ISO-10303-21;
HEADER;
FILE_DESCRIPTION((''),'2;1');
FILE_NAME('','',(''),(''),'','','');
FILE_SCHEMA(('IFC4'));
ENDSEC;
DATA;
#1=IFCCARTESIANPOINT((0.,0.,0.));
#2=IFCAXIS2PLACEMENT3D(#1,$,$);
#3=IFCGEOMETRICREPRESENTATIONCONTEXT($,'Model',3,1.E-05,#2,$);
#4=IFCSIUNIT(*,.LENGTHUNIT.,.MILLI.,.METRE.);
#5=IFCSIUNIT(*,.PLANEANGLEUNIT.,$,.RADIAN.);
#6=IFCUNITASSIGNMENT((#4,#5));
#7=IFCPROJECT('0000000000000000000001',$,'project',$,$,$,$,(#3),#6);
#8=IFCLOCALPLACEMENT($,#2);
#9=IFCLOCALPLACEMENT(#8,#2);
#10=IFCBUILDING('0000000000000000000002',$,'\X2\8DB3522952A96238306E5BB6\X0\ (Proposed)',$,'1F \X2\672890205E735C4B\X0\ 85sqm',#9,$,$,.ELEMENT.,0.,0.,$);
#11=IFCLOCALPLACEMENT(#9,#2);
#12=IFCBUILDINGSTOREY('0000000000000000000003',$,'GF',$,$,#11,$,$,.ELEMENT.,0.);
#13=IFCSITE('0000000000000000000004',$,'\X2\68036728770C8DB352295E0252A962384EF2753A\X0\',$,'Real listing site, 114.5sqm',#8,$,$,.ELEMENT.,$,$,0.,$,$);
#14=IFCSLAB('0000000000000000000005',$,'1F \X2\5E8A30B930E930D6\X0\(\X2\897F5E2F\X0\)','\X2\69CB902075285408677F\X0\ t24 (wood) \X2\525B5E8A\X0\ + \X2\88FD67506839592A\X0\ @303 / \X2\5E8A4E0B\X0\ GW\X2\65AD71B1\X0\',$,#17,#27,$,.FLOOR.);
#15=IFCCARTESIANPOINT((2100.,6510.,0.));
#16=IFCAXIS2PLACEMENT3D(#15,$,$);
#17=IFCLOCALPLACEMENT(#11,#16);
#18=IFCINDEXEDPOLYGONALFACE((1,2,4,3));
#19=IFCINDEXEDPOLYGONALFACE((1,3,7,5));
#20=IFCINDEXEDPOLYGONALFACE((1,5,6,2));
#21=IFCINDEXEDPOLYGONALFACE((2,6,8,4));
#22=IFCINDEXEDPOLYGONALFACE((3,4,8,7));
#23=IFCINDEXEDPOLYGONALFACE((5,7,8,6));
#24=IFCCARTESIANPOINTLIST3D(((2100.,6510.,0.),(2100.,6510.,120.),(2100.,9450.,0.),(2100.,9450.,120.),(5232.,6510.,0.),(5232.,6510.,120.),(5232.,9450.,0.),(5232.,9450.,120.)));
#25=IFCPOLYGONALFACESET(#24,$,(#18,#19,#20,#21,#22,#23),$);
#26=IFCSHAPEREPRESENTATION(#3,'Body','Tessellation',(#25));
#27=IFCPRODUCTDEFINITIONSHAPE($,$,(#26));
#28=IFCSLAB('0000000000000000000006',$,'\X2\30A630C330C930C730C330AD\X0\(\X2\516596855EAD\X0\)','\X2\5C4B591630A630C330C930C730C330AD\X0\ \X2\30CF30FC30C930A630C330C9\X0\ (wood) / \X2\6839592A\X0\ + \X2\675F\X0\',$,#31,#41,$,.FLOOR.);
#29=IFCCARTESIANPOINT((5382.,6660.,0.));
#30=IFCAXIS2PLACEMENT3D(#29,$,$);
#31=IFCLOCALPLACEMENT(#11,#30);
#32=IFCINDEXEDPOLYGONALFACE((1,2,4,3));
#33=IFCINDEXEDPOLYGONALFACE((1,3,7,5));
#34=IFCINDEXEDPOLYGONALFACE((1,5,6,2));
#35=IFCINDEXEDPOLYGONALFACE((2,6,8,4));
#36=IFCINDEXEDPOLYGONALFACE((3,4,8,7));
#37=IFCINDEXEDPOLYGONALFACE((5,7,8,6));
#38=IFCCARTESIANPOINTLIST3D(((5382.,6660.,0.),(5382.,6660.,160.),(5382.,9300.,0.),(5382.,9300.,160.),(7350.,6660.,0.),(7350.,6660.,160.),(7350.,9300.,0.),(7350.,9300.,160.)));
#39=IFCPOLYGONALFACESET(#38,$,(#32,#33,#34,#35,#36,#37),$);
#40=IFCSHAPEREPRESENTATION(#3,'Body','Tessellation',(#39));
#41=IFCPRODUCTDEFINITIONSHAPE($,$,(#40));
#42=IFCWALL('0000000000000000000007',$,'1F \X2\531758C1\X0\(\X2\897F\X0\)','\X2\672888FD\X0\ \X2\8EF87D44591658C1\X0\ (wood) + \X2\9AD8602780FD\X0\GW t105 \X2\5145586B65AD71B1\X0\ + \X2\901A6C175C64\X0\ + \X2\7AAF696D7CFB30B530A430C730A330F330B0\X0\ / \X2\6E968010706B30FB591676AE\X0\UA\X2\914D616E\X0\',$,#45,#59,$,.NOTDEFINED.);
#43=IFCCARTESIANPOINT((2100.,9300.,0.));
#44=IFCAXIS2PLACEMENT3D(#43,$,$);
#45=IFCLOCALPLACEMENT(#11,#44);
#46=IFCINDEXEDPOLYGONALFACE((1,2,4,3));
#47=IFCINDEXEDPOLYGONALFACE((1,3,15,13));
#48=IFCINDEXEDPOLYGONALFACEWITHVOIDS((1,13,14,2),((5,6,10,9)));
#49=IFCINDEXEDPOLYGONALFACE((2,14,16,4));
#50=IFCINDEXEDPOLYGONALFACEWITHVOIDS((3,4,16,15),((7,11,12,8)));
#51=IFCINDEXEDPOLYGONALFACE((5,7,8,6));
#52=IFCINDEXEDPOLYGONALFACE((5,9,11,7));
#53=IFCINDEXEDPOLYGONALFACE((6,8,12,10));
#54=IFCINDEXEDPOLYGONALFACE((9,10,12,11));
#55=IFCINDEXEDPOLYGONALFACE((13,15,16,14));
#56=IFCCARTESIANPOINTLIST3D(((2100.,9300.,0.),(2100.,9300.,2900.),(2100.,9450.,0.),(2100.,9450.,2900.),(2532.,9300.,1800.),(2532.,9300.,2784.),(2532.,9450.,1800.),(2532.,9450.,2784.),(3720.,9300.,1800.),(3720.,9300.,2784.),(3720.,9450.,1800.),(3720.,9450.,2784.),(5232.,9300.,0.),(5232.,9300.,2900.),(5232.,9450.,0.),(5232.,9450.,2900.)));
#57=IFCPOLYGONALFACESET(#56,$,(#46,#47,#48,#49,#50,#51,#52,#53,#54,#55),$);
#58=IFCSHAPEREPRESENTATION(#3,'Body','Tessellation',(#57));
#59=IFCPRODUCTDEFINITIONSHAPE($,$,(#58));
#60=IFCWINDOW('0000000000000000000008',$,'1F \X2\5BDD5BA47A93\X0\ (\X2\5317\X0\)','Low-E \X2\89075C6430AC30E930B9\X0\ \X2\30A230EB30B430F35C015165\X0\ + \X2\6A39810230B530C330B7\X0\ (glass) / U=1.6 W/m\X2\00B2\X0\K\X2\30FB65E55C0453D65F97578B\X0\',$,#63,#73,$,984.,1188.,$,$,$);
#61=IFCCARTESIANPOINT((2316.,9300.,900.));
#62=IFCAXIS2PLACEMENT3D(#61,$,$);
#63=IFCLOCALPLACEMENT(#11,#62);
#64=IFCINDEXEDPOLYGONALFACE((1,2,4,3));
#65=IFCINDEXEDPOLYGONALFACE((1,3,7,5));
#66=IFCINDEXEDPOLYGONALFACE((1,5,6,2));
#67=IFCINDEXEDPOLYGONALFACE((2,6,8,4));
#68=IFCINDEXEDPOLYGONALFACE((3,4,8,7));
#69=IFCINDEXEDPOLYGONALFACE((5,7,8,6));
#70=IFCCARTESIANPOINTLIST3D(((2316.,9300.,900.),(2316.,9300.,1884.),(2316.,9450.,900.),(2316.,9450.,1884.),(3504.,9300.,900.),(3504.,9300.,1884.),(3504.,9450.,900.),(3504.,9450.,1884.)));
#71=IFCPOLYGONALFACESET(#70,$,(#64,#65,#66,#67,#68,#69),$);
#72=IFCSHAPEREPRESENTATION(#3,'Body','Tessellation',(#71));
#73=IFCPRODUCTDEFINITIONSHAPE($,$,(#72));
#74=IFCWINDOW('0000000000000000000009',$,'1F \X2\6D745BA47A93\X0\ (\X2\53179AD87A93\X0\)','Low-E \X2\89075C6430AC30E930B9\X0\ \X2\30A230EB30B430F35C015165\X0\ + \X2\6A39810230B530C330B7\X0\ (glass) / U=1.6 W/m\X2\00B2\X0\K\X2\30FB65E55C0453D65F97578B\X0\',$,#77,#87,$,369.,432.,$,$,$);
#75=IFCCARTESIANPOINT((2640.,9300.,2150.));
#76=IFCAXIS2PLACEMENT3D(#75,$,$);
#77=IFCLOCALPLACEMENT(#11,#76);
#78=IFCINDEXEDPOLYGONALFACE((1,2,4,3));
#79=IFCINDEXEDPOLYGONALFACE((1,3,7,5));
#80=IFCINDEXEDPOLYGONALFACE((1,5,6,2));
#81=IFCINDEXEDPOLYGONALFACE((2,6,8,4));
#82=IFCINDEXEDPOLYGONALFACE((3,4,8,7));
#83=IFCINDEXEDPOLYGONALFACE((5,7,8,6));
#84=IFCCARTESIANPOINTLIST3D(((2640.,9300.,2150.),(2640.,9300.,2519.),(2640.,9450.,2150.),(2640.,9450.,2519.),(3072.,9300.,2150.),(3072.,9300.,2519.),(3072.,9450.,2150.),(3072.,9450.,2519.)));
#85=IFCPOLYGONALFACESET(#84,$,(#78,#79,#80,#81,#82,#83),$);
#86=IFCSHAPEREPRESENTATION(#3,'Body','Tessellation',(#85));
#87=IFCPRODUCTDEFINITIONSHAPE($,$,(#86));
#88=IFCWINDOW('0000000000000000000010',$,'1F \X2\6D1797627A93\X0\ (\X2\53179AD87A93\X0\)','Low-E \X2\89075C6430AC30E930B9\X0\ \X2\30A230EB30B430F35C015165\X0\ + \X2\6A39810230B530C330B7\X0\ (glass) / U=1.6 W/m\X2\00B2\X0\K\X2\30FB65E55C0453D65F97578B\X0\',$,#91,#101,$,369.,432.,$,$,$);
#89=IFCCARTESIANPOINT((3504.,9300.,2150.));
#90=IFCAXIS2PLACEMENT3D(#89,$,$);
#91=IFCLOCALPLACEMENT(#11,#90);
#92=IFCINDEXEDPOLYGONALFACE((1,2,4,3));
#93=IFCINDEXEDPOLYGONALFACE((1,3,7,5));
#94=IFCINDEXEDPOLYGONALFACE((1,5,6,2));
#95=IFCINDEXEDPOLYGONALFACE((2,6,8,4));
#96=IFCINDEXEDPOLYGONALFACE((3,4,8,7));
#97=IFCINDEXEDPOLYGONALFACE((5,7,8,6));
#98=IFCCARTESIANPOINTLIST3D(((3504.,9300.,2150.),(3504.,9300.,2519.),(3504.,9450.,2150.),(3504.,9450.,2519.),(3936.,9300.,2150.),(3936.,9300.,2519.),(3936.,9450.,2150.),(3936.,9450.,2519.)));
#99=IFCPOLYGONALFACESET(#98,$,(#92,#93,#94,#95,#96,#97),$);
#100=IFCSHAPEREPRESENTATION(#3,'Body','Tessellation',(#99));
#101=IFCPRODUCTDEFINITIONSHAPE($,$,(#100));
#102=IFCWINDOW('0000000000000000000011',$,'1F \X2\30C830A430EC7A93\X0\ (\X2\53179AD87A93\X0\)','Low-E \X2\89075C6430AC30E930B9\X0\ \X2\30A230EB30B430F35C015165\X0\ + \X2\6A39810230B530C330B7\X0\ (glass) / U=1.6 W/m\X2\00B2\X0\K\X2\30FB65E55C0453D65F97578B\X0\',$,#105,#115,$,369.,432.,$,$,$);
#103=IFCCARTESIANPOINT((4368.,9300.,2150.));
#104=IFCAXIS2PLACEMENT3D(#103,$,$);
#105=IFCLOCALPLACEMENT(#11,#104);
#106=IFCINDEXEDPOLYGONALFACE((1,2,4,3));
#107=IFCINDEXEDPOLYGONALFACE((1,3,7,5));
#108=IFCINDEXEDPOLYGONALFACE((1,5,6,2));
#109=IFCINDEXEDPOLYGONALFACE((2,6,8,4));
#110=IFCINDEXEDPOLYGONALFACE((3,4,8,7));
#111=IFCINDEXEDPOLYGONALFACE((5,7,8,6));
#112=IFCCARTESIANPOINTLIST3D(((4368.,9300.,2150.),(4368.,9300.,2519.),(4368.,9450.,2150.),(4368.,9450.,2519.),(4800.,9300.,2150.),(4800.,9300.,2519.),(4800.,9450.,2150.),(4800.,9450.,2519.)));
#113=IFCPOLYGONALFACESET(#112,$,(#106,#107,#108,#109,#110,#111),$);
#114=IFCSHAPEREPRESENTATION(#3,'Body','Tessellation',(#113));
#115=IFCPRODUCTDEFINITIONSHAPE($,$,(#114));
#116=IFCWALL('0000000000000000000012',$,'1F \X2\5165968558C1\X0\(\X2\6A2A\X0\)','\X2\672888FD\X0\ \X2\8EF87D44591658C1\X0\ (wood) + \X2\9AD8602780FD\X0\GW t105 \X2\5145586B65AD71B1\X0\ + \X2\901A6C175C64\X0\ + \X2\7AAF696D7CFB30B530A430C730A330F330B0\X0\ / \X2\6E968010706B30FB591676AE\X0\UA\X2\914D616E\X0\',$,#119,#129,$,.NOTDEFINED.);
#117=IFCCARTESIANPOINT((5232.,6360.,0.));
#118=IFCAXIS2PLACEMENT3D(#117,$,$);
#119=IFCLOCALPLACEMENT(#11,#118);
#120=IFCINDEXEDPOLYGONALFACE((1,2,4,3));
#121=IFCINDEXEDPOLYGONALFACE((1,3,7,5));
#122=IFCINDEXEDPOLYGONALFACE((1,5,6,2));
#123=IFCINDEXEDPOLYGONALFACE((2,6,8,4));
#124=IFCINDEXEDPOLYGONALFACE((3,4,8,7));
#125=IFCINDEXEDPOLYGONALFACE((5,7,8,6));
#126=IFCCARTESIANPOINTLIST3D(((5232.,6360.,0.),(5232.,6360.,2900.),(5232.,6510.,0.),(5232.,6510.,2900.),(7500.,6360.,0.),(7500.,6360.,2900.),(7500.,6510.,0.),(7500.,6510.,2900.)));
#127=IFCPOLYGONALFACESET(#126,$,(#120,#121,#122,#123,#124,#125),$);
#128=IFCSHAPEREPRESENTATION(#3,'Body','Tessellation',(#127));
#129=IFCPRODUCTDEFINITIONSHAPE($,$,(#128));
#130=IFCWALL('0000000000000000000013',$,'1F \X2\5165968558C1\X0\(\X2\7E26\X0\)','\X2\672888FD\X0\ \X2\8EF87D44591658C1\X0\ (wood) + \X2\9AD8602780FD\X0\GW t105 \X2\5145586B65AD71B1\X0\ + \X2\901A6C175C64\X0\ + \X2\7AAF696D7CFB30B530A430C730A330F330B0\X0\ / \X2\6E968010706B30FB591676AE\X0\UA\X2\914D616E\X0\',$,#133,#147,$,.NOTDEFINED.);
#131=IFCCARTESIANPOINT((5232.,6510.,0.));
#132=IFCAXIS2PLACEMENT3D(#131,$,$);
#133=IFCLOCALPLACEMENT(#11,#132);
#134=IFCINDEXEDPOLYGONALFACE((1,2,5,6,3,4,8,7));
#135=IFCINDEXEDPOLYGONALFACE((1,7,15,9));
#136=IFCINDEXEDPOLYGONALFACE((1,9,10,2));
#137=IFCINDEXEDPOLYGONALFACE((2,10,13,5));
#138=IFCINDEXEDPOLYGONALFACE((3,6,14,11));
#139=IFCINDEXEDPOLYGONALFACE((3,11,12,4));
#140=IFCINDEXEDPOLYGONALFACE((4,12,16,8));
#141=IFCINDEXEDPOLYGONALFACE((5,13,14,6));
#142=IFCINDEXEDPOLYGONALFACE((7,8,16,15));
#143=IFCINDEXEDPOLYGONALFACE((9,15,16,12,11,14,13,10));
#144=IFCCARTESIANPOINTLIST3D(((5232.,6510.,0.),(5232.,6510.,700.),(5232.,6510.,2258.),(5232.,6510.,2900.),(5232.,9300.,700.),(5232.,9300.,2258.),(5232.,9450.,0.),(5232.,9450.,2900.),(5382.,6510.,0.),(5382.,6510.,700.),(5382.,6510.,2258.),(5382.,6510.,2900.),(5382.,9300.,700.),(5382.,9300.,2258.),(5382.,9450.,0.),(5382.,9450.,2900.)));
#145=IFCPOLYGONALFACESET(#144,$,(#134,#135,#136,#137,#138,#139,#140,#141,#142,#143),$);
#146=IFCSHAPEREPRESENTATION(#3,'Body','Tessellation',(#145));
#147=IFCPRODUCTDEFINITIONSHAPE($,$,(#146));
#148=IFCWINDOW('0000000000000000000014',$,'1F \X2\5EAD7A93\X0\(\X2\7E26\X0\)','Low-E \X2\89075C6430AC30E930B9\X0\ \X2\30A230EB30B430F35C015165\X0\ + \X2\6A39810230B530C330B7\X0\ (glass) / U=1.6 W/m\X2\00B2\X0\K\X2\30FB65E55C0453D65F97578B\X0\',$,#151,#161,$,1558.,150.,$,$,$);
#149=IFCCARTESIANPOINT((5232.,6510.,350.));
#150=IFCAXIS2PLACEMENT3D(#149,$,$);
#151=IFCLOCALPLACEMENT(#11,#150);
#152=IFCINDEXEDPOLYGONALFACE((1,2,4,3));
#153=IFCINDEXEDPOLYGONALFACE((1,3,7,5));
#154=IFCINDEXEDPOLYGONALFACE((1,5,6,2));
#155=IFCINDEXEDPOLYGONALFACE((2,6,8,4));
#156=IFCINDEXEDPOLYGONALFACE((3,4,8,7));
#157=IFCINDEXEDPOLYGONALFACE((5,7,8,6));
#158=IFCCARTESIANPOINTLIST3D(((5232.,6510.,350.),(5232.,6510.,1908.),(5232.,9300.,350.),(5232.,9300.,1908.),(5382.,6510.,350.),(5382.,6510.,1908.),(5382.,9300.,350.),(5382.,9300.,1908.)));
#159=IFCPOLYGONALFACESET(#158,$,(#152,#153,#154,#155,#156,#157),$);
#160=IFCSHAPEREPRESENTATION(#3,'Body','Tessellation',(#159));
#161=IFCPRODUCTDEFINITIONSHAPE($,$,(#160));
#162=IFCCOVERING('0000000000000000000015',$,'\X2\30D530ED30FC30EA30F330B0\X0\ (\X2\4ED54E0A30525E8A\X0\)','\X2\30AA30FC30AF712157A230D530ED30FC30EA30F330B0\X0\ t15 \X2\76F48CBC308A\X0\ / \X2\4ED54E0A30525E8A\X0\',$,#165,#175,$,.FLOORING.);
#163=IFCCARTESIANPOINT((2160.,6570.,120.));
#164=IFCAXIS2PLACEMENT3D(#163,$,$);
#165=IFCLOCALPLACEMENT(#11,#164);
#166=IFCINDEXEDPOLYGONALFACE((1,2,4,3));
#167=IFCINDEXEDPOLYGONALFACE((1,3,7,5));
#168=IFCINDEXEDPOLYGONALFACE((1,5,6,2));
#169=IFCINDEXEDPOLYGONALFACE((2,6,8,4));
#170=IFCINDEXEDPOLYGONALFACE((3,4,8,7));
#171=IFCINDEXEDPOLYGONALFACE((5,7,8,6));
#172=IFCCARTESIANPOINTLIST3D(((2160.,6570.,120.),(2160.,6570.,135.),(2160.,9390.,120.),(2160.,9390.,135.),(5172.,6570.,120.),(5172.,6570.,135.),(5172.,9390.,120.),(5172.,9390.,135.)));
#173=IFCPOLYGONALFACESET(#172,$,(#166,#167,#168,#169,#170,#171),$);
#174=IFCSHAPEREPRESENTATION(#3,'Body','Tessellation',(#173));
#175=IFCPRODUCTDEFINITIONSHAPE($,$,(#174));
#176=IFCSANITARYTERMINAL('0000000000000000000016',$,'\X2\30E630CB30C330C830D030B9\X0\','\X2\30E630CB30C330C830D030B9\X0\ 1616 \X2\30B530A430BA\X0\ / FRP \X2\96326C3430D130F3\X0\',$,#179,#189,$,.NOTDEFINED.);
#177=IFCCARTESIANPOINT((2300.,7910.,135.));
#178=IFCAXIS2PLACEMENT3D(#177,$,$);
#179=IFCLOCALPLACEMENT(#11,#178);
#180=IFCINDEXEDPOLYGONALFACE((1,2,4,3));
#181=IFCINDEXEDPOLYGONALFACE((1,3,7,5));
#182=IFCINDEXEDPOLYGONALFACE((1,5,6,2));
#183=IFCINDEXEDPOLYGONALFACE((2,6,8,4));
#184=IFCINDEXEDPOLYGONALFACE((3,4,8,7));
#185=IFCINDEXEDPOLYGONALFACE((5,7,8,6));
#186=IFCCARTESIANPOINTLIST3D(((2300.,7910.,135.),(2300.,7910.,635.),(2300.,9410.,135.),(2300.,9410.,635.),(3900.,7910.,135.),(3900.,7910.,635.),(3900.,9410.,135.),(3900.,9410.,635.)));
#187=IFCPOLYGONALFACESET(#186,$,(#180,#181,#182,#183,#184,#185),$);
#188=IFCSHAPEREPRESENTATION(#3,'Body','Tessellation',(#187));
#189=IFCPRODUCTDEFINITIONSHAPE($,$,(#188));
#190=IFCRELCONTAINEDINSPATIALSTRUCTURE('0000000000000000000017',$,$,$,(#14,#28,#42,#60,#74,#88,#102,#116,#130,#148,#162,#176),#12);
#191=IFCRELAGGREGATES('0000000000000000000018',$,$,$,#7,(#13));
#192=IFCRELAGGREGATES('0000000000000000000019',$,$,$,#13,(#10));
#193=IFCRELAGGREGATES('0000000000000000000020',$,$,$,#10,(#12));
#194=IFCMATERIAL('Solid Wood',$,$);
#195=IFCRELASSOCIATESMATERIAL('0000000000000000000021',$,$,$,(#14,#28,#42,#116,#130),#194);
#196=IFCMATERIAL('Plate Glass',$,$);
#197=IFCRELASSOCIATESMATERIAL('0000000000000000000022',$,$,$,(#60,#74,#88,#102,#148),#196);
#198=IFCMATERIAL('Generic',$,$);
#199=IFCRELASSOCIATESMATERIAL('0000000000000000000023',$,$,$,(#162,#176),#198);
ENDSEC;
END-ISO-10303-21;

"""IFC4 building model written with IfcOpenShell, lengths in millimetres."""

from ifc_helpers import new_model, si_unit, frame, frame_2d, origin, place, context, project, spatial, rectangle, extrude, material, element, fill, save


model = new_model("IFC4")

# Units and contexts
model_context = context("Model", 3, precision=1e-05, world=origin())
ifc_project = project(units=[si_unit("LENGTHUNIT", "METRE", prefix="MILLI"), si_unit("PLANEANGLEUNIT", "RADIAN")], contexts=[model_context])

# Site, building, storey
site_placement = place(None, origin())
site = spatial("IfcSite", under=ifc_project, at=site_placement, Name="栃木県足利市助戸仲町", ObjectType="Real listing site, 114.5sqm", CompositionType="ELEMENT", RefElevation=0.0)
building_placement = place(site_placement, origin())
building = spatial("IfcBuilding", under=site, at=building_placement, Name="足利助戸の家 (Proposed)", ObjectType="1F 木造平屋 85sqm", CompositionType="ELEMENT", ElevationOfRefHeight=0.0, ElevationOfTerrain=0.0)
storey_placement = place(building_placement, origin())
storey = spatial("IfcBuildingStorey", under=building, at=storey_placement, Name="GF", CompositionType="ELEMENT", Elevation=0.0)

# Slabs
ifc_material_1 = material(Name="Solid Wood")
slab_1_placement = place(storey_placement, frame((2100.0, 6510.0, 0.0)))
element("IfcSlab", 1, at=slab_1_placement, inside=storey, material=ifc_material_1, Name="1F 床スラブ(西帯)", Description="構造用合板 t24 (wood) 剛床 + 製材根太 @303 / 床下 GW断熱", PredefinedType="FLOOR", context=model_context, shape_type="SweptSolid", body=[
    extrude(rectangle(XDim=3132.0, YDim=2940.0, at=frame_2d((1566.0, 1470.0))), frame((2100.0, 6510.0, 0.0)), (0.0, 0.0, 1.0), 120.0),
])
slab_2_placement = place(storey_placement, frame((5382.0, 6660.0, 0.0)))
element("IfcSlab", 2, at=slab_2_placement, inside=storey, material=ifc_material_1, Name="ウッドデッキ(入隅庭)", Description="屋外ウッドデッキ ハードウッド (wood) / 根太 + 束", PredefinedType="FLOOR", context=model_context, shape_type="SweptSolid", body=[
    extrude(rectangle(XDim=1968.0, YDim=2640.0, at=frame_2d((984.0, 1320.0))), frame((5382.0, 6660.0, 0.0)), (0.0, 0.0, 1.0), 160.0),
])

# Wall, openings, windows
wall_1_placement = place(storey_placement, frame((2100.0, 9300.0, 0.0)))
wall_1 = element("IfcWall", 3, at=wall_1_placement, inside=storey, material=ifc_material_1, Name="1F 北壁(西)", Description="木製 軸組外壁 (wood) + 高性能GW t105 充填断熱 + 通気層 + 窯業系サイディング / 準耐火・外皮UA配慮", PredefinedType="NOTDEFINED", context=model_context, shape_type="SweptSolid", body=[
    extrude(rectangle(XDim=3132.0, YDim=150.0, at=frame_2d((1566.0, 75.0))), frame((2100.0, 9300.0, 0.0)), (0.0, 0.0, 1.0), 2900.0),
])
opening_1_placement = place(storey_placement, frame((2316.0, 9300.0, 900.0)))
opening_1 = element("IfcOpeningElement", 4, at=opening_1_placement, cuts=wall_1, PredefinedType="NOTDEFINED", context=model_context, shape_type="SweptSolid", body=[
    extrude(rectangle(XDim=1188.0, YDim=150.0, at=frame_2d((594.0, 75.0))), frame((2316.0, 9300.0, 900.0)), (0.0, 0.0, 1.0), 984.0),
])
opening_2_placement = place(storey_placement, frame((2640.0, 9300.0, 2150.0)))
opening_2 = element("IfcOpeningElement", 5, at=opening_2_placement, cuts=wall_1, PredefinedType="NOTDEFINED", context=model_context, shape_type="SweptSolid", body=[
    extrude(rectangle(XDim=432.0, YDim=150.0, at=frame_2d((216.0, 75.0))), frame((2640.0, 9300.0, 2150.0)), (0.0, 0.0, 1.0), 369.0),
])
opening_3_placement = place(storey_placement, frame((3504.0, 9300.0, 2150.0)))
opening_3 = element("IfcOpeningElement", 6, at=opening_3_placement, cuts=wall_1, PredefinedType="NOTDEFINED", context=model_context, shape_type="SweptSolid", body=[
    extrude(rectangle(XDim=432.0, YDim=150.0, at=frame_2d((216.0, 75.0))), frame((3504.0, 9300.0, 2150.0)), (0.0, 0.0, 1.0), 369.0),
])
opening_4_placement = place(storey_placement, frame((4368.0, 9300.0, 2150.0)))
opening_4 = element("IfcOpeningElement", 7, at=opening_4_placement, cuts=wall_1, PredefinedType="NOTDEFINED", context=model_context, shape_type="SweptSolid", body=[
    extrude(rectangle(XDim=432.0, YDim=150.0, at=frame_2d((216.0, 75.0))), frame((4368.0, 9300.0, 2150.0)), (0.0, 0.0, 1.0), 369.0),
])
ifc_material_2 = material(Name="Plate Glass")
window_1_placement = place(storey_placement, frame((2316.0, 9300.0, 900.0)))
window_1 = element("IfcWindow", 8, at=window_1_placement, inside=storey, material=ifc_material_2, Name="1F 寝室窓 (北)", Description="Low-E 複層ガラス アルゴン封入 + 樹脂サッシ (glass) / U=1.6 W/m²K・日射取得型", OverallHeight=984.0, OverallWidth=1188.0, context=model_context, shape_type="SweptSolid", body=[
    extrude(rectangle(XDim=1188.0, YDim=150.0, at=frame_2d((594.0, 75.0))), frame((2316.0, 9300.0, 900.0)), (0.0, 0.0, 1.0), 984.0),
])
fill(opening_1, window_1)
window_2_placement = place(storey_placement, frame((2640.0, 9300.0, 2150.0)))
window_2 = element("IfcWindow", 9, at=window_2_placement, inside=storey, material=ifc_material_2, Name="1F 浴室窓 (北高窓)", Description="Low-E 複層ガラス アルゴン封入 + 樹脂サッシ (glass) / U=1.6 W/m²K・日射取得型", OverallHeight=369.0, OverallWidth=432.0, context=model_context, shape_type="SweptSolid", body=[
    extrude(rectangle(XDim=432.0, YDim=150.0, at=frame_2d((216.0, 75.0))), frame((2640.0, 9300.0, 2150.0)), (0.0, 0.0, 1.0), 369.0),
])
fill(opening_2, window_2)
window_3_placement = place(storey_placement, frame((3504.0, 9300.0, 2150.0)))
window_3 = element("IfcWindow", 10, at=window_3_placement, inside=storey, material=ifc_material_2, Name="1F 洗面窓 (北高窓)", Description="Low-E 複層ガラス アルゴン封入 + 樹脂サッシ (glass) / U=1.6 W/m²K・日射取得型", OverallHeight=369.0, OverallWidth=432.0, context=model_context, shape_type="SweptSolid", body=[
    extrude(rectangle(XDim=432.0, YDim=150.0, at=frame_2d((216.0, 75.0))), frame((3504.0, 9300.0, 2150.0)), (0.0, 0.0, 1.0), 369.0),
])
fill(opening_3, window_3)
window_4_placement = place(storey_placement, frame((4368.0, 9300.0, 2150.0)))
window_4 = element("IfcWindow", 11, at=window_4_placement, inside=storey, material=ifc_material_2, Name="1F トイレ窓 (北高窓)", Description="Low-E 複層ガラス アルゴン封入 + 樹脂サッシ (glass) / U=1.6 W/m²K・日射取得型", OverallHeight=369.0, OverallWidth=432.0, context=model_context, shape_type="SweptSolid", body=[
    extrude(rectangle(XDim=432.0, YDim=150.0, at=frame_2d((216.0, 75.0))), frame((4368.0, 9300.0, 2150.0)), (0.0, 0.0, 1.0), 369.0),
])
fill(opening_4, window_4)

# Wall
wall_2_placement = place(storey_placement, frame((5232.0, 6360.0, 0.0)))
element("IfcWall", 12, at=wall_2_placement, inside=storey, material=ifc_material_1, Name="1F 入隅壁(横)", Description="木製 軸組外壁 (wood) + 高性能GW t105 充填断熱 + 通気層 + 窯業系サイディング / 準耐火・外皮UA配慮", PredefinedType="NOTDEFINED", context=model_context, shape_type="SweptSolid", body=[
    extrude(rectangle(XDim=2268.0, YDim=150.0, at=frame_2d((1134.0, 75.0))), frame((5232.0, 6360.0, 0.0)), (0.0, 0.0, 1.0), 2900.0),
])

# Wall, opening, window
wall_3_placement = place(storey_placement, frame((5232.0, 6510.0, 0.0)))
wall_3 = element("IfcWall", 13, at=wall_3_placement, inside=storey, material=ifc_material_1, Name="1F 入隅壁(縦)", Description="木製 軸組外壁 (wood) + 高性能GW t105 充填断熱 + 通気層 + 窯業系サイディング / 準耐火・外皮UA配慮", PredefinedType="NOTDEFINED", context=model_context, shape_type="SweptSolid", body=[
    extrude(rectangle(XDim=150.0, YDim=2940.0, at=frame_2d((75.0, 1470.0))), frame((5232.0, 6510.0, 0.0)), (0.0, 0.0, 1.0), 2900.0),
])
opening_5_placement = place(storey_placement, frame((5232.0, 6510.0, 350.0)))
opening_5 = element("IfcOpeningElement", 14, at=opening_5_placement, cuts=wall_3, PredefinedType="NOTDEFINED", context=model_context, shape_type="SweptSolid", body=[
    extrude(rectangle(XDim=150.0, YDim=2790.0, at=frame_2d((75.0, 1395.0))), frame((5232.0, 6510.0, 350.0)), (0.0, 0.0, 1.0), 1558.0),
])
window_5_placement = place(storey_placement, frame((5232.0, 6510.0, 350.0)))
window_5 = element("IfcWindow", 15, at=window_5_placement, inside=storey, material=ifc_material_2, Name="1F 庭窓(縦)", Description="Low-E 複層ガラス アルゴン封入 + 樹脂サッシ (glass) / U=1.6 W/m²K・日射取得型", OverallHeight=1558.0, OverallWidth=150.0, context=model_context, shape_type="SweptSolid", body=[
    extrude(rectangle(XDim=150.0, YDim=2790.0, at=frame_2d((75.0, 1395.0))), frame((5232.0, 6510.0, 350.0)), (0.0, 0.0, 1.0), 1558.0),
])
fill(opening_5, window_5)

# Covering
ifc_material_3 = material(Name="Generic")
covering_placement = place(storey_placement, frame((2160.0, 6570.0, 120.0)))
element("IfcCovering", 16, at=covering_placement, inside=storey, material=ifc_material_3, Name="フローリング (仕上げ床)", Description="オーク無垢フローリング t15 直貼り / 仕上げ床", PredefinedType="FLOORING", context=model_context, shape_type="SweptSolid", body=[
    extrude(rectangle(XDim=3012.0, YDim=2820.0, at=frame_2d((1506.0, 1410.0))), frame((2160.0, 6570.0, 120.0)), (0.0, 0.0, 1.0), 15.0),
])

# Sanitary terminal
sanitary_terminal_1_placement = place(storey_placement, frame((2300.0, 7910.0, 135.0)))
element("IfcSanitaryTerminal", 17, at=sanitary_terminal_1_placement, inside=storey, material=ifc_material_3, Name="ユニットバス", Description="ユニットバス 1616 サイズ / FRP 防水パン", PredefinedType="NOTDEFINED", context=model_context, shape_type="SweptSolid", body=[
    extrude(rectangle(XDim=1600.0, YDim=1500.0, at=frame_2d((800.0, 750.0))), frame((2300.0, 7910.0, 135.0)), (0.0, 0.0, 1.0), 500.0),
])

save(model, "model.ifc")
